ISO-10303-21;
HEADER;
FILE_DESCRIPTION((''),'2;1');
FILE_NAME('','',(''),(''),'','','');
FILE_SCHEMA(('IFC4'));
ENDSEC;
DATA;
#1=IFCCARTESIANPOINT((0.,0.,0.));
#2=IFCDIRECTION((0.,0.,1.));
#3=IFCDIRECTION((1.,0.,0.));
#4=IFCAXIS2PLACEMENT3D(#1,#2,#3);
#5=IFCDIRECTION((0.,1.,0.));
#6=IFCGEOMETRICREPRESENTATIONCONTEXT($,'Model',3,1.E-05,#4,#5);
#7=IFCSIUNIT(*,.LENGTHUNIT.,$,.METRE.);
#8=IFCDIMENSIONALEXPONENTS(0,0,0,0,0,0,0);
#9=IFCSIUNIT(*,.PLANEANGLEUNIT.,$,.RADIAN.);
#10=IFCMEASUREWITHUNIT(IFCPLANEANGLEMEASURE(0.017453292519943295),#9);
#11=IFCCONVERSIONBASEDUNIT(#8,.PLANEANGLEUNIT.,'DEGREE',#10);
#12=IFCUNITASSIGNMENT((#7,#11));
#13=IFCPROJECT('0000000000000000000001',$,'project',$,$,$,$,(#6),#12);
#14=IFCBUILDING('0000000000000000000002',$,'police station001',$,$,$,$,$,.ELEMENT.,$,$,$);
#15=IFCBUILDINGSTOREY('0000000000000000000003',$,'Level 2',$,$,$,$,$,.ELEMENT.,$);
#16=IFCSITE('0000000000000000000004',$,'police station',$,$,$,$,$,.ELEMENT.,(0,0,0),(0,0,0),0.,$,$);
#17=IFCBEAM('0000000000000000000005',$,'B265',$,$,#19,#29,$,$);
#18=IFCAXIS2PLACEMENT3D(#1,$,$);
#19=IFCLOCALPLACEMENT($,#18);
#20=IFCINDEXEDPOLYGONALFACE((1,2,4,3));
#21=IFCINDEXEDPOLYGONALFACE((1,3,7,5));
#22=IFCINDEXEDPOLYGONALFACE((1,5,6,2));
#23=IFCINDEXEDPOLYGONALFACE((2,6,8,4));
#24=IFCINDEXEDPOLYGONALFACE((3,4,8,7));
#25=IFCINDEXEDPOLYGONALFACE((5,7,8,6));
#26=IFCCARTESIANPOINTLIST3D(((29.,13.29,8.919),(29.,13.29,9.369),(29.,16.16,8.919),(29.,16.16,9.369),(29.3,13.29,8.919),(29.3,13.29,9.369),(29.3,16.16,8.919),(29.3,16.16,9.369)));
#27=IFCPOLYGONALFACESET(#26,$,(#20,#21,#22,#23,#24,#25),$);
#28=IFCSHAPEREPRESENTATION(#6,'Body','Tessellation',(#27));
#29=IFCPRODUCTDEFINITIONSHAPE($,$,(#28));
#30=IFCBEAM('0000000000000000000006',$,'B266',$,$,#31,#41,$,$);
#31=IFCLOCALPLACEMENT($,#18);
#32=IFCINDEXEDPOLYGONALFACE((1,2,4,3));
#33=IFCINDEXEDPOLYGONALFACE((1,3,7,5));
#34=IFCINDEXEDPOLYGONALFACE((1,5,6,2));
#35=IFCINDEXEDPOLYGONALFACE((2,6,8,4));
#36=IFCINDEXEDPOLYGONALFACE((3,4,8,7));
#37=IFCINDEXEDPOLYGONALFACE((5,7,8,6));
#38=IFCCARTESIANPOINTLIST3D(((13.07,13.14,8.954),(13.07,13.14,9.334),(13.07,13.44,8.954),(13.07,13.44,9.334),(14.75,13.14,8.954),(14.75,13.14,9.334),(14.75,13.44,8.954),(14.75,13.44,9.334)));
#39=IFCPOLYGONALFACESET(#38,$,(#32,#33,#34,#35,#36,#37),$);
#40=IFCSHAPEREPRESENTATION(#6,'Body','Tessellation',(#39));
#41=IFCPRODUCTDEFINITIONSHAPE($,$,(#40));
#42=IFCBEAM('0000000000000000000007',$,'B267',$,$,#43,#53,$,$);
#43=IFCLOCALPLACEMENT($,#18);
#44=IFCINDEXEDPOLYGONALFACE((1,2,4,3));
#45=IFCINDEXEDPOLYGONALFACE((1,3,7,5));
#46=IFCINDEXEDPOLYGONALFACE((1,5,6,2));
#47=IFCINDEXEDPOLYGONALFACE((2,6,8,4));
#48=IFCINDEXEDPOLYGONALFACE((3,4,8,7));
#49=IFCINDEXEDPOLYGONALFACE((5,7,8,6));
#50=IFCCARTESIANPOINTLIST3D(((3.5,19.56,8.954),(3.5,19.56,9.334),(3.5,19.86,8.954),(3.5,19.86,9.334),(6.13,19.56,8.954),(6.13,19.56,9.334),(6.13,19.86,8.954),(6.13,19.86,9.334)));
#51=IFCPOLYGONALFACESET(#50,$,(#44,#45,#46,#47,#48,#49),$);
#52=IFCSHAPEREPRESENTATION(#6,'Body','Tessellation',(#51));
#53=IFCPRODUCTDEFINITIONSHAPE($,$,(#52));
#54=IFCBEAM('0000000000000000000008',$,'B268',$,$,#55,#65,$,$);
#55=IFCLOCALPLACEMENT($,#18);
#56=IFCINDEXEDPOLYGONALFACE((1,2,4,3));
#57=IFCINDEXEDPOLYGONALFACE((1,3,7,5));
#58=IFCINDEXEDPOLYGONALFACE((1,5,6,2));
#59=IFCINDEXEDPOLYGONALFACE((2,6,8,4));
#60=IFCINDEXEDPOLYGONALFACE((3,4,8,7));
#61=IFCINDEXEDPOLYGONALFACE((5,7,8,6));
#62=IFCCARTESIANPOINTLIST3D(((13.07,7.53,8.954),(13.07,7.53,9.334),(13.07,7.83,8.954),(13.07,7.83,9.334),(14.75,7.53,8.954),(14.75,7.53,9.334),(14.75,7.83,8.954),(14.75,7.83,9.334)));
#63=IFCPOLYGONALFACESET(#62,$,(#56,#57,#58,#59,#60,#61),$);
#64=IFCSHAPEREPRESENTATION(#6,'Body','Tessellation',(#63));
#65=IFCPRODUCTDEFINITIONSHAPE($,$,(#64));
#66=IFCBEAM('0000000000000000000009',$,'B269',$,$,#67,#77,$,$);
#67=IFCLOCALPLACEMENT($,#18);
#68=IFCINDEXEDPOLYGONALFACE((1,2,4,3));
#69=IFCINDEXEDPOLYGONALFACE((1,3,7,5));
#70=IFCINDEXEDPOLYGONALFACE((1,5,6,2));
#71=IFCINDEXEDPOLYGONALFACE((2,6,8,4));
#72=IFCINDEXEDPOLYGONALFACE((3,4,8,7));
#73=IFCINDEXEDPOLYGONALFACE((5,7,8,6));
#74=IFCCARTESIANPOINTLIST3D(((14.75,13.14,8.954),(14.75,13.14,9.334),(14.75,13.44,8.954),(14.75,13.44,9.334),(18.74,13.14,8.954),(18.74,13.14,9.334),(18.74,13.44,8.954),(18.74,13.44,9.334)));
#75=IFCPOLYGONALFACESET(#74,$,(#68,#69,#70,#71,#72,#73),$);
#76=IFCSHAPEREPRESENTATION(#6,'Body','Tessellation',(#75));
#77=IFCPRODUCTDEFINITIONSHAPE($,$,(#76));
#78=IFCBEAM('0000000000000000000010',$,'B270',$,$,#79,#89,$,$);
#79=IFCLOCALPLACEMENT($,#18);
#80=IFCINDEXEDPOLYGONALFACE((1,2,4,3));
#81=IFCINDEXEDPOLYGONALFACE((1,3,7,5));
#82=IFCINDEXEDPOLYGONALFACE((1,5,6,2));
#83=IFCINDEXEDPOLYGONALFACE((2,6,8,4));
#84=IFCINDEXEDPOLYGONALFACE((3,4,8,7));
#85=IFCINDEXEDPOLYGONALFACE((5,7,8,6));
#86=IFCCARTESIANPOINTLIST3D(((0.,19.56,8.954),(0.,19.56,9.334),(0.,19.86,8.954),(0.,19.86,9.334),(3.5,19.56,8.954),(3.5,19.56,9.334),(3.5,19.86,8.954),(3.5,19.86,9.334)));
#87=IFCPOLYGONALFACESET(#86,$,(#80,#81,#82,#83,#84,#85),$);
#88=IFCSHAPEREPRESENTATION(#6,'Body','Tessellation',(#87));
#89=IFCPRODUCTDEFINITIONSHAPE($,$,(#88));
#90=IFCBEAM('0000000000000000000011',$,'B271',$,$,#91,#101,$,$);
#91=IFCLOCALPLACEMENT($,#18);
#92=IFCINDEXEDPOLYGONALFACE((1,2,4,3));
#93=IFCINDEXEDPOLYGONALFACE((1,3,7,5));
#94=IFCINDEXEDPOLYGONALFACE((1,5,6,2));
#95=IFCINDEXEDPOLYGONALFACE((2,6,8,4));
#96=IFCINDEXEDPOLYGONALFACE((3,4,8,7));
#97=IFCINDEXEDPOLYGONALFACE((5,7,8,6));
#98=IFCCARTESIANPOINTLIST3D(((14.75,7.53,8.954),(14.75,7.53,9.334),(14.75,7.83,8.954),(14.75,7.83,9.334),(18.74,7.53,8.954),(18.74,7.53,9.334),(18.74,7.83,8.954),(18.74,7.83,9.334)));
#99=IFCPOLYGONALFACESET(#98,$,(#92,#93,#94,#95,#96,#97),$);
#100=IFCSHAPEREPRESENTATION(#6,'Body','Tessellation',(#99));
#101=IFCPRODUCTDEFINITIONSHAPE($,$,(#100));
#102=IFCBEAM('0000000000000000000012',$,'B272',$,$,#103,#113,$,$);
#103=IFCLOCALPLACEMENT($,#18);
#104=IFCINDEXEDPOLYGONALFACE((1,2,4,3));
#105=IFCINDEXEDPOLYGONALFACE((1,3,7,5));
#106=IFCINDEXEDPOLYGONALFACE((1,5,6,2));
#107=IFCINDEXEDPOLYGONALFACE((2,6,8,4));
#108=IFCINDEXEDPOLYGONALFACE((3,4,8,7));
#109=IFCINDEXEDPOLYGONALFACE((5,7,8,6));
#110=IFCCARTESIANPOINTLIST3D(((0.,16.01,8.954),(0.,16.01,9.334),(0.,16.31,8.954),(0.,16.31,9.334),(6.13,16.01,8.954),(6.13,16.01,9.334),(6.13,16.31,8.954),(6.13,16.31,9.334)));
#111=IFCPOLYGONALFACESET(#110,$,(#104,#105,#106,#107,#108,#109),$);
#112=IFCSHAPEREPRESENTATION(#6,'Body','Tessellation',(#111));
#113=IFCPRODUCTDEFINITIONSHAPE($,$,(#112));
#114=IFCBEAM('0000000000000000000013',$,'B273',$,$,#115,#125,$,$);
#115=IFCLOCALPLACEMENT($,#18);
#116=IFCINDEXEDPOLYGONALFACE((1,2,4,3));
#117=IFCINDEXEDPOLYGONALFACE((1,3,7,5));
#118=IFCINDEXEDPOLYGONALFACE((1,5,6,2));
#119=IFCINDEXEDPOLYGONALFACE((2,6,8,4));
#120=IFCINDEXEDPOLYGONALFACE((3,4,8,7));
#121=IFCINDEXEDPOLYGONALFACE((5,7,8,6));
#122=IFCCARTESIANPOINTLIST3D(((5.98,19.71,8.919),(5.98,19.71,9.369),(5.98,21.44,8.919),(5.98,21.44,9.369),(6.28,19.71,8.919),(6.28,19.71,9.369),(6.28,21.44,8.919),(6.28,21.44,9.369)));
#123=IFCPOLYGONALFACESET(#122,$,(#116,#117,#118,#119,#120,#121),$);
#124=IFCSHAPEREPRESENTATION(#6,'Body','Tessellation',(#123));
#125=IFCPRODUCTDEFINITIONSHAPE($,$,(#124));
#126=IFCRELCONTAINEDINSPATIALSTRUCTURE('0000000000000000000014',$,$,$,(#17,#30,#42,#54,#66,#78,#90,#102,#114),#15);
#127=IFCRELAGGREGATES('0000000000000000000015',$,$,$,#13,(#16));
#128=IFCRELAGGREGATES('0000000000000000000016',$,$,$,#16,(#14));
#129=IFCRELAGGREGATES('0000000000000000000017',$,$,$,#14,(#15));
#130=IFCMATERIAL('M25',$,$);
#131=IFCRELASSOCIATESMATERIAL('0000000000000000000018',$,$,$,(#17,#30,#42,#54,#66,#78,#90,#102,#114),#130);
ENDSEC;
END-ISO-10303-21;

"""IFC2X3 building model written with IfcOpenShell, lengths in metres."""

from ifc_helpers import new_model, entity, si_unit, converted_unit, direction, frame, frame_2d, origin_with_axes, place, context, project, spatial, rectangle, extrude, material, element, save


model = new_model("IFC2X3")

# Units and contexts
model_context = context("Model", 3, precision=1e-05, world=origin_with_axes(), true_north=direction((0.0, 1.0, 0.0)))
ifc_project = project(units=[si_unit("LENGTHUNIT", "METRE"), converted_unit("PLANEANGLEUNIT", "DEGREE", entity("IfcPlaneAngleMeasure", 0.017453292519943295), si_unit("PLANEANGLEUNIT", "RADIAN"), dimensions=[0, 0, 0, 0, 0, 0, 0])], contexts=[model_context])

# Site, building, storey
site = spatial("IfcSite", under=ifc_project, Name="police station", CompositionType="ELEMENT", RefLatitude=(0, 0, 0), RefLongitude=(0, 0, 0), RefElevation=0.0)
building = spatial("IfcBuilding", under=site, Name="police station001", CompositionType="ELEMENT")
storey = spatial("IfcBuildingStorey", under=building, Name="Level 2", CompositionType="ELEMENT")

# Beams
ifc_material = material(Name="M25")
placement = place(None, origin_with_axes())
element("IfcBeam", 1, at=placement, inside=storey, material=ifc_material, Name="B265", context=model_context, shape_type="SweptSolid", body=[
    extrude(rectangle(XDim=0.3, YDim=0.45, at=frame_2d((0.0, 0.0), x_axis=(0.0, 1.0, 0.0))), frame((29.15, 13.29, 9.144), z_axis=(0.0, 1.0, 0.0), x_axis=(0.0, 0.0, -1.0)), (0.0, 0.0, 1.0), 2.87),
])
element("IfcBeam", 2, at=placement, inside=storey, material=ifc_material, Name="B266", context=model_context, shape_type="SweptSolid", body=[
    extrude(rectangle(XDim=0.3, YDim=0.38, at=frame_2d((0.0, 0.0), x_axis=(0.0, 1.0, 0.0))), frame((13.07, 13.29, 9.144), z_axis=(1.0, 0.0, 0.0), x_axis=(0.0, 0.0, -1.0)), (0.0, 0.0, 1.0), 1.68),
])
element("IfcBeam", 3, at=placement, inside=storey, material=ifc_material, Name="B267", context=model_context, shape_type="SweptSolid", body=[
    extrude(rectangle(XDim=0.3, YDim=0.38, at=frame_2d((0.0, 0.0), x_axis=(0.0, 1.0, 0.0))), frame((3.5, 19.71, 9.144), z_axis=(1.0, 0.0, 0.0), x_axis=(0.0, 0.0, -1.0)), (0.0, 0.0, 1.0), 2.63),
])
element("IfcBeam", 4, at=placement, inside=storey, material=ifc_material, Name="B268", context=model_context, shape_type="SweptSolid", body=[
    extrude(rectangle(XDim=0.3, YDim=0.38, at=frame_2d((0.0, 0.0), x_axis=(0.0, 1.0, 0.0))), frame((13.07, 7.68, 9.144), z_axis=(1.0, 0.0, 0.0), x_axis=(0.0, 0.0, -1.0)), (0.0, 0.0, 1.0), 1.68),
])
element("IfcBeam", 5, at=placement, inside=storey, material=ifc_material, Name="B269", context=model_context, shape_type="SweptSolid", body=[
    extrude(rectangle(XDim=0.3, YDim=0.38, at=frame_2d((0.0, 0.0), x_axis=(0.0, 1.0, 0.0))), frame((14.75, 13.29, 9.144), z_axis=(1.0, 0.0, 0.0), x_axis=(0.0, 0.0, -1.0)), (0.0, 0.0, 1.0), 3.99),
])
element("IfcBeam", 6, at=placement, inside=storey, material=ifc_material, Name="B270", context=model_context, shape_type="SweptSolid", body=[
    extrude(rectangle(XDim=0.3, YDim=0.38, at=frame_2d((0.0, 0.0), x_axis=(0.0, 1.0, 0.0))), frame((0.0, 19.71, 9.144), z_axis=(1.0, 0.0, 0.0), x_axis=(0.0, 0.0, -1.0)), (0.0, 0.0, 1.0), 3.5),
])
element("IfcBeam", 7, at=placement, inside=storey, material=ifc_material, Name="B271", context=model_context, shape_type="SweptSolid", body=[
    extrude(rectangle(XDim=0.3, YDim=0.38, at=frame_2d((0.0, 0.0), x_axis=(0.0, 1.0, 0.0))), frame((14.75, 7.68, 9.144), z_axis=(1.0, 0.0, 0.0), x_axis=(0.0, 0.0, -1.0)), (0.0, 0.0, 1.0), 3.99),
])
element("IfcBeam", 8, at=placement, inside=storey, material=ifc_material, Name="B272", context=model_context, shape_type="SweptSolid", body=[
    extrude(rectangle(XDim=0.3, YDim=0.38, at=frame_2d((0.0, 0.0), x_axis=(0.0, 1.0, 0.0))), frame((6.13, 16.16, 9.144), z_axis=(-1.0, 0.0, 0.0), x_axis=(0.0, 0.0, -1.0)), (0.0, 0.0, 1.0), 6.13),
])
element("IfcBeam", 9, at=placement, inside=storey, material=ifc_material, Name="B273", context=model_context, shape_type="SweptSolid", body=[
    extrude(rectangle(XDim=0.3, YDim=0.45, at=frame_2d((0.0, 0.0), x_axis=(0.0, 1.0, 0.0))), frame((6.13, 19.71, 9.144), z_axis=(0.0, 1.0, 0.0), x_axis=(0.0, 0.0, -1.0)), (0.0, 0.0, 1.0), 1.73),
])

save(model, "model.ifc")
